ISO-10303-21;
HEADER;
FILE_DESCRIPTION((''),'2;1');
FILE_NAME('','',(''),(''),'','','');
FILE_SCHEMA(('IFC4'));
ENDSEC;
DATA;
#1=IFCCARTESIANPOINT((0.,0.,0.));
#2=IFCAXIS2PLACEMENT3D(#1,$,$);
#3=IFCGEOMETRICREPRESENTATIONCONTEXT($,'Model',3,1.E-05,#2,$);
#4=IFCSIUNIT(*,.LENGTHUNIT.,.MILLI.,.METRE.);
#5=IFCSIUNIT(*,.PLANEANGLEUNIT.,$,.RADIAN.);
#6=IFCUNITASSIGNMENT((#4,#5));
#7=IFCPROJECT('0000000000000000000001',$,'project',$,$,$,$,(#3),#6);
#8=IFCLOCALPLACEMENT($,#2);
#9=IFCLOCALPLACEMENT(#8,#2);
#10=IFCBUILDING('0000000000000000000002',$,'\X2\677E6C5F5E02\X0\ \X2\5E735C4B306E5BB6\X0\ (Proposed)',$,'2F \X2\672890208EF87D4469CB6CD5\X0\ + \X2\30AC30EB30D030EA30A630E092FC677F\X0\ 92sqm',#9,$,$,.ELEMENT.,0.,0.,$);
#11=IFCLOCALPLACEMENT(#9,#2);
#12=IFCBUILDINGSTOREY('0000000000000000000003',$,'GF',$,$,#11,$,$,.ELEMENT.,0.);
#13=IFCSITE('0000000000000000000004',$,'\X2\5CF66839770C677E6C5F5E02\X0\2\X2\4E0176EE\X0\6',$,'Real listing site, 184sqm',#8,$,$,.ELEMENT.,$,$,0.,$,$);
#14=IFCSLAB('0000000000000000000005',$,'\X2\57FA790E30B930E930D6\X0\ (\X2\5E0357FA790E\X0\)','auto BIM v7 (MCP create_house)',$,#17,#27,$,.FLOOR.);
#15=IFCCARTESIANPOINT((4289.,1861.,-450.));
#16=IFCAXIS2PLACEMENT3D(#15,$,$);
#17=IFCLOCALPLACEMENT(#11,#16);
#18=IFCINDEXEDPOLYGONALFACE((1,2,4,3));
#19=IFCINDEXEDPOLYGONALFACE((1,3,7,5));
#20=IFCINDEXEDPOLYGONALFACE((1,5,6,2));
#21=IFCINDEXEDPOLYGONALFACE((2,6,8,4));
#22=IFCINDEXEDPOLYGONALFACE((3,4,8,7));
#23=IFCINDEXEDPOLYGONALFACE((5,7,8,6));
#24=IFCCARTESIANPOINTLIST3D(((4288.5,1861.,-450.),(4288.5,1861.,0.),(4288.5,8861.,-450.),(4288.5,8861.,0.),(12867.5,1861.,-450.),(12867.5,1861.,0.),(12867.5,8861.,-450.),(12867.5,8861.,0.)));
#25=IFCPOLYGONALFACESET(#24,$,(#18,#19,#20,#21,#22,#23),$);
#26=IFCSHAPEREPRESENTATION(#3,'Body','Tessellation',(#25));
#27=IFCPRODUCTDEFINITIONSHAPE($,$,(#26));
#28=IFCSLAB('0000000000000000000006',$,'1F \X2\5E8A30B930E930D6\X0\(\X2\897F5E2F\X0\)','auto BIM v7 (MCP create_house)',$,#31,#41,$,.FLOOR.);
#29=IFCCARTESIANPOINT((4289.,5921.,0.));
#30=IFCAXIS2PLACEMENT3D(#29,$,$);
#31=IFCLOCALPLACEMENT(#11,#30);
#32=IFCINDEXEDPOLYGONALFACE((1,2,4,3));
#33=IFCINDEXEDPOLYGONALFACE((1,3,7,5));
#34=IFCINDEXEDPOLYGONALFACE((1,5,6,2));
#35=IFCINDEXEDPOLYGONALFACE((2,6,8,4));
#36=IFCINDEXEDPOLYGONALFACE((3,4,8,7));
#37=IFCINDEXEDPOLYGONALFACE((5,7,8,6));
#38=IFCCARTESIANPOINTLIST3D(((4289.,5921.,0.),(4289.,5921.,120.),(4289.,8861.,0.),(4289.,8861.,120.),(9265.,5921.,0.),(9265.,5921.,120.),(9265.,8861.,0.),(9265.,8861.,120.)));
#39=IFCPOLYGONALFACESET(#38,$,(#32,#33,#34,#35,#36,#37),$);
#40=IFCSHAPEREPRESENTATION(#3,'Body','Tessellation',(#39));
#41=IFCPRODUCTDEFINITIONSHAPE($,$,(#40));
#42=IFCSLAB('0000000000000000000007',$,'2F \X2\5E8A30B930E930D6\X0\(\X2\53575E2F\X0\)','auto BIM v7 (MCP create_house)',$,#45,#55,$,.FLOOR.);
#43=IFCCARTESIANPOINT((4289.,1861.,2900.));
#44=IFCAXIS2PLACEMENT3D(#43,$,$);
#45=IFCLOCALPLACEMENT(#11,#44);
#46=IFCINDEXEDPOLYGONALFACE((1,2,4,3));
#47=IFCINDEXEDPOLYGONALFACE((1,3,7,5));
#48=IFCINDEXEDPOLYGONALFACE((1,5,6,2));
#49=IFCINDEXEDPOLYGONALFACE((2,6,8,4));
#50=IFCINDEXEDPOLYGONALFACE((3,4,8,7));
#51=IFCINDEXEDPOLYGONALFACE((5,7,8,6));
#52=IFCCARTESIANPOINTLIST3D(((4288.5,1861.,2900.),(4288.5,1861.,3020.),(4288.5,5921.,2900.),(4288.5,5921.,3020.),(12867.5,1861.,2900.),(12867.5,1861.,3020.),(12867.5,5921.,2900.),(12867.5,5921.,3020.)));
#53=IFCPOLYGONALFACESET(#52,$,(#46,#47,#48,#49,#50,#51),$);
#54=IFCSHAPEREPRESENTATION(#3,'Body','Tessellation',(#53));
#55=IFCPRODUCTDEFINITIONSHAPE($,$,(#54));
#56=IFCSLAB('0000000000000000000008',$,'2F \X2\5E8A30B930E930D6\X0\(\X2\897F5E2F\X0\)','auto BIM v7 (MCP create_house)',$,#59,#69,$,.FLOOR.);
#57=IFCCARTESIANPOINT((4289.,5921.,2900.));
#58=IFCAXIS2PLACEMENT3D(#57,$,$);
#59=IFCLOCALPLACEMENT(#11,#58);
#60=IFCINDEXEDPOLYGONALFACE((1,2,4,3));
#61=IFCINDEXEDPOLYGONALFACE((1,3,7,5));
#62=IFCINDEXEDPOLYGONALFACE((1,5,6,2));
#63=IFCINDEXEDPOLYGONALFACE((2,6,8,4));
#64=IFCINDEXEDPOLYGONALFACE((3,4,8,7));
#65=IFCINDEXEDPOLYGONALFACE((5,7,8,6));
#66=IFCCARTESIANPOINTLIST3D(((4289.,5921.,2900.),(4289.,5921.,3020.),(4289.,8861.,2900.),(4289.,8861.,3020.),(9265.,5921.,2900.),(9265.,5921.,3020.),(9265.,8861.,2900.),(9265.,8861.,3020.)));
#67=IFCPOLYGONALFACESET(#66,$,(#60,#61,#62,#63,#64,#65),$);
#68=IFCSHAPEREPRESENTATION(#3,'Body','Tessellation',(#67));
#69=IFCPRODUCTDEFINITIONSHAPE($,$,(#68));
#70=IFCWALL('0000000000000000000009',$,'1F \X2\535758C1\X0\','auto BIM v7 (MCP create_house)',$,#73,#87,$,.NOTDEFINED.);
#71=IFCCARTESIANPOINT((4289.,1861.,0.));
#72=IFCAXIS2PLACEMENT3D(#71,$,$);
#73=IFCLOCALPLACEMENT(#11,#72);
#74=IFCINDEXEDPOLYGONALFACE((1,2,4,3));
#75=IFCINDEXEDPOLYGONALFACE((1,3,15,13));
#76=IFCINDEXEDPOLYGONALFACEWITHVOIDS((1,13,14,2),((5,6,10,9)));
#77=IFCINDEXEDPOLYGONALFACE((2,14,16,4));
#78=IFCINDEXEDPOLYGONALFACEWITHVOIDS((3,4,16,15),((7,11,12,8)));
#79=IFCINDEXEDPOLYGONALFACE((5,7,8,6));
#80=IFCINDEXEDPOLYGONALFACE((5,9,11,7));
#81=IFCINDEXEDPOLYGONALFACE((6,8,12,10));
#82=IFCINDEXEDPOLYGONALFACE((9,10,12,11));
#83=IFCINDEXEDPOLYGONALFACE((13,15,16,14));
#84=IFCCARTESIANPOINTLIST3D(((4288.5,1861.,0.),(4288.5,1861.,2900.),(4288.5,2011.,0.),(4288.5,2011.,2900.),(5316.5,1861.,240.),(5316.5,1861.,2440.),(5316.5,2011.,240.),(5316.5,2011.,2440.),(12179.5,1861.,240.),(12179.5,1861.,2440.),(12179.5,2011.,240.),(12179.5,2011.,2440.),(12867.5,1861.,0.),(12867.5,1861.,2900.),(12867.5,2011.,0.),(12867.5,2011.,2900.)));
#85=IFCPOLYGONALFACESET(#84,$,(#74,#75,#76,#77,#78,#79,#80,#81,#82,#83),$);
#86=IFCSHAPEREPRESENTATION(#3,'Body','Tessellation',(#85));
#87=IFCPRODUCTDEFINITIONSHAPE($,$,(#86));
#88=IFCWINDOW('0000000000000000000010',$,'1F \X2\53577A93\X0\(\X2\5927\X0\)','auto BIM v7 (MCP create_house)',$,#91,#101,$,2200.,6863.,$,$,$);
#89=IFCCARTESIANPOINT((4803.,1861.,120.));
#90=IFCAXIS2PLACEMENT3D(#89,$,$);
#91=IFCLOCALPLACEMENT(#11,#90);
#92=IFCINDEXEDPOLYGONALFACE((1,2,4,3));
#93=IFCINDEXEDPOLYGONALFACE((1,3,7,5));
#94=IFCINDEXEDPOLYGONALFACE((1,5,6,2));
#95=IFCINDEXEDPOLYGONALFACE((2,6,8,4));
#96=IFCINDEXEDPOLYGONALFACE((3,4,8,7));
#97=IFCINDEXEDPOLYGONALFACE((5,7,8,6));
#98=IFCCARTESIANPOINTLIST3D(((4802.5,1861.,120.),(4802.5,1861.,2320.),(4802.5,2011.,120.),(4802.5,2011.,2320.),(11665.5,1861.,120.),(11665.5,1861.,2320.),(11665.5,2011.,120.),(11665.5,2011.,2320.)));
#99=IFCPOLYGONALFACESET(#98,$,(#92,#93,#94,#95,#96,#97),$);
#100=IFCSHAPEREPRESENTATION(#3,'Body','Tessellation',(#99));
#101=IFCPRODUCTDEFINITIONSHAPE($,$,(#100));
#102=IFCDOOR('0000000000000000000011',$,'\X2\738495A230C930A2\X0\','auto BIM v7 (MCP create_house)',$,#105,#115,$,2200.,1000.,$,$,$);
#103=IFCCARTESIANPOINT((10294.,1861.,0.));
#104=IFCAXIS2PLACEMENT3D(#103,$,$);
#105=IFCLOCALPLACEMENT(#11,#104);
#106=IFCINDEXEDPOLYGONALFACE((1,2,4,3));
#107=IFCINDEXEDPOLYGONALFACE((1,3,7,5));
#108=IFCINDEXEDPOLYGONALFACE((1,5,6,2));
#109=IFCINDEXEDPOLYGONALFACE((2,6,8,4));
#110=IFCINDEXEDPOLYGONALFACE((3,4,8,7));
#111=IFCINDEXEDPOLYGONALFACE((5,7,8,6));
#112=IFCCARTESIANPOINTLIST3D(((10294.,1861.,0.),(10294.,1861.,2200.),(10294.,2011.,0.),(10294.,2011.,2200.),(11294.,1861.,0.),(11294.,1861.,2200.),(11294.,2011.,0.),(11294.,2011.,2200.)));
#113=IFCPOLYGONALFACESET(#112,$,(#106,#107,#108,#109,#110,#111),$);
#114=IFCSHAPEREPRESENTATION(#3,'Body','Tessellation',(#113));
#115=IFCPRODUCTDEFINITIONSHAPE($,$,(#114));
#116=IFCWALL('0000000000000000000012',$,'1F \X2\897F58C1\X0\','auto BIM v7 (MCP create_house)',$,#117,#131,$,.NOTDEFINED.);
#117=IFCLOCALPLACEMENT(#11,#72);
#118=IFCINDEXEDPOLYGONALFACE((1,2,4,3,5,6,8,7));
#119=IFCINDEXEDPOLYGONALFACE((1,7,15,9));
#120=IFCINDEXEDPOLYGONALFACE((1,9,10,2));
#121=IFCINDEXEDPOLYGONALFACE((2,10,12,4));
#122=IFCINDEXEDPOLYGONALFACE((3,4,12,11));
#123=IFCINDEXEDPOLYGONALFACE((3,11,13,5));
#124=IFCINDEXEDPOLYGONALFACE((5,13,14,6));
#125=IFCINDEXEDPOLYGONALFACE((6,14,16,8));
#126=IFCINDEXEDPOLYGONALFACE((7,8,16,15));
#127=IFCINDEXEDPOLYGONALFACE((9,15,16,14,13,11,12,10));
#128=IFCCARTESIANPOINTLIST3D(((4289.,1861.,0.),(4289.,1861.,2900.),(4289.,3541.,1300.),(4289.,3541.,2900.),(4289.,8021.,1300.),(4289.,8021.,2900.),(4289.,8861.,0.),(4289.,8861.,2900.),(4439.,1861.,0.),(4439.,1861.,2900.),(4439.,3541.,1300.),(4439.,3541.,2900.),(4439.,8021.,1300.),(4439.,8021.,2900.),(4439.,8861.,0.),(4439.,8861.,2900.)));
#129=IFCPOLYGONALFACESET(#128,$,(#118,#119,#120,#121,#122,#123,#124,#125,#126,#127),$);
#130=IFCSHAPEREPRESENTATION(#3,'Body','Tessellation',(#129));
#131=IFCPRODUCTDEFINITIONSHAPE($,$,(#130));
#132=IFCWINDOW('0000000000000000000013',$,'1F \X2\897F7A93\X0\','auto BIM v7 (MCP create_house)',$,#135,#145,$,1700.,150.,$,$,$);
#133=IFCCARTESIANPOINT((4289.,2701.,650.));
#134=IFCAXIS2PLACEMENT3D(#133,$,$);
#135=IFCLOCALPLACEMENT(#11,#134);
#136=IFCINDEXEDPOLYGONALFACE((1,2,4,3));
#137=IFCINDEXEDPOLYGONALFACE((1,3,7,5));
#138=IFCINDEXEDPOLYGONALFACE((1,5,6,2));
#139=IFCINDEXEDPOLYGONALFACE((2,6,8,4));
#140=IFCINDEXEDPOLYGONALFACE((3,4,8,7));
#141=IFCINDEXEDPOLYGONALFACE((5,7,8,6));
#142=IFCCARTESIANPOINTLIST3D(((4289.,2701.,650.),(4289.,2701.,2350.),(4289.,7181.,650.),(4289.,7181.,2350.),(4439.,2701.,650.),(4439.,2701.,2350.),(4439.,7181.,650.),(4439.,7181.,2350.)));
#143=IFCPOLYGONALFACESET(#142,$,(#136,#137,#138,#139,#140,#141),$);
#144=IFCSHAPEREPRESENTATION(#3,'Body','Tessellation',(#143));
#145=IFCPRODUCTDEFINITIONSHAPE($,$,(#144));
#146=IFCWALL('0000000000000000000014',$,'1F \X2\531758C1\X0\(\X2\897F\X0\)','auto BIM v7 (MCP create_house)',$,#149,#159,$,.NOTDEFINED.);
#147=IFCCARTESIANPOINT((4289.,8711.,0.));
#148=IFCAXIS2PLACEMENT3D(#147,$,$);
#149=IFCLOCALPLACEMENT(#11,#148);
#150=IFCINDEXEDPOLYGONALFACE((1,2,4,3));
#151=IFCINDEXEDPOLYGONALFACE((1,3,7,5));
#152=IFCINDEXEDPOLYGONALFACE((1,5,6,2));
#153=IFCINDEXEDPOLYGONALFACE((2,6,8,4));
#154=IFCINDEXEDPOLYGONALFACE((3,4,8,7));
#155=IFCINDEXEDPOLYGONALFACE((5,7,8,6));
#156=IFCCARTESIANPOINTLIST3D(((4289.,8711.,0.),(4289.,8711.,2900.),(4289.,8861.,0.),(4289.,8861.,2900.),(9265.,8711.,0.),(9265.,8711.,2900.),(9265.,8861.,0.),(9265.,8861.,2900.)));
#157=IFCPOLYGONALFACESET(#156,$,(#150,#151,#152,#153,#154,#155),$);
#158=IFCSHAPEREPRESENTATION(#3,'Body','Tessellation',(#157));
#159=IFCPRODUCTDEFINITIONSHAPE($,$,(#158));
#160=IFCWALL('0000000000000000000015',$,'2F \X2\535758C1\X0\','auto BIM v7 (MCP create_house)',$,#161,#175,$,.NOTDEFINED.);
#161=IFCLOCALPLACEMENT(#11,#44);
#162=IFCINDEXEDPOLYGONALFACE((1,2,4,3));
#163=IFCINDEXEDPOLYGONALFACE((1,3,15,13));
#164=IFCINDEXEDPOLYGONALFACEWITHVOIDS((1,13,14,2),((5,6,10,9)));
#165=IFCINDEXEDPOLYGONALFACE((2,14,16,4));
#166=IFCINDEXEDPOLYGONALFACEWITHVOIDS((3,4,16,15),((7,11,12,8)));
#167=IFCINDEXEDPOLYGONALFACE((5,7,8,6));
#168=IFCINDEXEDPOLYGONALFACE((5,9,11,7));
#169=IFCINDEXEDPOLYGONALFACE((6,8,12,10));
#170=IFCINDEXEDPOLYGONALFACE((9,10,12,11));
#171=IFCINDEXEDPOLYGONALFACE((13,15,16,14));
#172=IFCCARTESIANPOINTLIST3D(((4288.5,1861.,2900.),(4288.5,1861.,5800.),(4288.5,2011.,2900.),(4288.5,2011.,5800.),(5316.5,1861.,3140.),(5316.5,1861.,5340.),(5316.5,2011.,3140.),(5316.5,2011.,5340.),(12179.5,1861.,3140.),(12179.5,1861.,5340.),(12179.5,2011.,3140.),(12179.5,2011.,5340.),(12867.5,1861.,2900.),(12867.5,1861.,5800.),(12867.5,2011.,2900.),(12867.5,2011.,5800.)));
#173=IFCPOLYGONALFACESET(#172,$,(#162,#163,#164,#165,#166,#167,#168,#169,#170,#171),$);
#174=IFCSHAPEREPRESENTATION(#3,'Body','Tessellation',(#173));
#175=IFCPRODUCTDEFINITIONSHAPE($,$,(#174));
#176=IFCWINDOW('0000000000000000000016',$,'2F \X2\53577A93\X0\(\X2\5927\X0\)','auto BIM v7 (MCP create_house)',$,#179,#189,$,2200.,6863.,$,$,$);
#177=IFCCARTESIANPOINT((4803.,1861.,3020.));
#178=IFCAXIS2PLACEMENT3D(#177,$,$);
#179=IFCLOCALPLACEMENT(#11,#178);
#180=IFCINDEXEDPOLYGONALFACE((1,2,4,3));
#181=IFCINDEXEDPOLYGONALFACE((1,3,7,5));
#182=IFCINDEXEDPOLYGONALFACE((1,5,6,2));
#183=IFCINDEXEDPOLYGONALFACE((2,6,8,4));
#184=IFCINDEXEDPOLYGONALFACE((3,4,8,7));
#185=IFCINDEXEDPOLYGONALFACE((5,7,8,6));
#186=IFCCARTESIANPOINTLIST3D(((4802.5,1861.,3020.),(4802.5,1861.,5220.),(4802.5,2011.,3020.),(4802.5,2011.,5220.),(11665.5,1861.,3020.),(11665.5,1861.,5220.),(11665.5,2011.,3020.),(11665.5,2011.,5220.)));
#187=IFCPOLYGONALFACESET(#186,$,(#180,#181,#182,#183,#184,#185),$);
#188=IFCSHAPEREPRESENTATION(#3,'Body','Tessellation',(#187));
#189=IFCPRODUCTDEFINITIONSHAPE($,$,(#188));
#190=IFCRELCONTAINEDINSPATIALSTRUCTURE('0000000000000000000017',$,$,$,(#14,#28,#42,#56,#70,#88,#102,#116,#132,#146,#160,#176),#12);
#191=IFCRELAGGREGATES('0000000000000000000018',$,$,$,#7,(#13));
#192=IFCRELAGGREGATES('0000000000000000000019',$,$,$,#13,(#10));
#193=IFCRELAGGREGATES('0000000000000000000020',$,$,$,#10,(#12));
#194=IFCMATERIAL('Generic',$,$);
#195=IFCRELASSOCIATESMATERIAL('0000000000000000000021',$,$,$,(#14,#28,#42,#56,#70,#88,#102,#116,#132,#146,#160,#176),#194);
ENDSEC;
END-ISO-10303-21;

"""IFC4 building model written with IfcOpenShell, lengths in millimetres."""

from ifc_helpers import new_model, si_unit, frame, frame_2d, origin, place, context, project, spatial, rectangle, extrude, material, element, fill, save


model = new_model("IFC4")

# Units and contexts
model_context = context("Model", 3, precision=1e-05, world=origin())
ifc_project = project(units=[si_unit("LENGTHUNIT", "METRE", prefix="MILLI"), si_unit("PLANEANGLEUNIT", "RADIAN")], contexts=[model_context])

# Site, building, storey
site_placement = place(None, origin())
site = spatial("IfcSite", under=ifc_project, at=site_placement, Name="島根県松江市2丁目6", ObjectType="Real listing site, 184sqm", CompositionType="ELEMENT", RefElevation=0.0)
building_placement = place(site_placement, origin())
building = spatial("IfcBuilding", under=site, at=building_placement, Name="松江市 平屋の家 (Proposed)", ObjectType="2F 木造軸組構法 + ガルバリウム鋼板 92sqm", CompositionType="ELEMENT", ElevationOfRefHeight=0.0, ElevationOfTerrain=0.0)
storey_placement = place(building_placement, origin())
storey = spatial("IfcBuildingStorey", under=building, at=storey_placement, Name="GF", CompositionType="ELEMENT", Elevation=0.0)

# Slabs
ifc_material = material(Name="Generic")
slab_1_placement = place(storey_placement, frame((4289.0, 1861.0, -450.0)))
element("IfcSlab", 1, at=slab_1_placement, inside=storey, material=ifc_material, Name="基礎スラブ (布基礎)", Description="auto BIM v7 (MCP create_house)", PredefinedType="FLOOR", context=model_context, shape_type="SweptSolid", body=[
    extrude(rectangle(XDim=8579.0, YDim=7000.0, at=frame_2d((4289.0, 3500.0))), frame((4289.0, 1861.0, -450.0)), (0.0, 0.0, 1.0), 450.0),
])
slab_2_placement = place(storey_placement, frame((4289.0, 5921.0, 0.0)))
element("IfcSlab", 2, at=slab_2_placement, inside=storey, material=ifc_material, Name="1F 床スラブ(西帯)", Description="auto BIM v7 (MCP create_house)", PredefinedType="FLOOR", context=model_context, shape_type="SweptSolid", body=[
    extrude(rectangle(XDim=4976.0, YDim=2940.0, at=frame_2d((2488.0, 1470.0))), frame((4289.0, 5921.0, 0.0)), (0.0, 0.0, 1.0), 120.0),
])
slab_3_placement = place(storey_placement, frame((4289.0, 1861.0, 2900.0)))
element("IfcSlab", 3, at=slab_3_placement, inside=storey, material=ifc_material, Name="2F 床スラブ(南帯)", Description="auto BIM v7 (MCP create_house)", PredefinedType="FLOOR", context=model_context, shape_type="SweptSolid", body=[
    extrude(rectangle(XDim=8579.0, YDim=4060.0, at=frame_2d((4289.0, 2030.0))), frame((4289.0, 1861.0, 2900.0)), (0.0, 0.0, 1.0), 120.0),
])
slab_4_placement = place(storey_placement, frame((4289.0, 5921.0, 2900.0)))
element("IfcSlab", 4, at=slab_4_placement, inside=storey, material=ifc_material, Name="2F 床スラブ(西帯)", Description="auto BIM v7 (MCP create_house)", PredefinedType="FLOOR", context=model_context, shape_type="SweptSolid", body=[
    extrude(rectangle(XDim=4976.0, YDim=2940.0, at=frame_2d((2488.0, 1470.0))), frame((4289.0, 5921.0, 2900.0)), (0.0, 0.0, 1.0), 120.0),
])

# Wall, openings, window, door
wall_1_placement = place(storey_placement, frame((4289.0, 1861.0, 0.0)))
wall_1 = element("IfcWall", 5, at=wall_1_placement, inside=storey, material=ifc_material, Name="1F 南壁", Description="auto BIM v7 (MCP create_house)", PredefinedType="NOTDEFINED", context=model_context, shape_type="SweptSolid", body=[
    extrude(rectangle(XDim=8579.0, YDim=150.0, at=frame_2d((4289.0, 75.0))), frame((4289.0, 1861.0, 0.0)), (0.0, 0.0, 1.0), 2900.0),
])
opening_1_placement = place(storey_placement, frame((4803.0, 1861.0, 120.0)))
opening_1 = element("IfcOpeningElement", 6, at=opening_1_placement, cuts=wall_1, PredefinedType="NOTDEFINED", context=model_context, shape_type="SweptSolid", body=[
    extrude(rectangle(XDim=6863.0, YDim=150.0, at=frame_2d((3431.0, 75.0))), frame((4803.0, 1861.0, 120.0)), (0.0, 0.0, 1.0), 2200.0),
])
opening_2_placement = place(storey_placement, frame((10294.0, 1861.0, 0.0)))
opening_2 = element("IfcOpeningElement", 7, at=opening_2_placement, cuts=wall_1, PredefinedType="NOTDEFINED", context=model_context, shape_type="SweptSolid", body=[
    extrude(rectangle(XDim=1000.0, YDim=150.0, at=frame_2d((500.0, 75.0))), frame((10294.0, 1861.0, 0.0)), (0.0, 0.0, 1.0), 2200.0),
])
window_1_placement = place(storey_placement, frame((4803.0, 1861.0, 120.0)))
window_1 = element("IfcWindow", 8, at=window_1_placement, inside=storey, material=ifc_material, Name="1F 南窓(大)", Description="auto BIM v7 (MCP create_house)", OverallHeight=2200.0, OverallWidth=6863.0, context=model_context, shape_type="SweptSolid", body=[
    extrude(rectangle(XDim=6863.0, YDim=150.0, at=frame_2d((3431.0, 75.0))), frame((4803.0, 1861.0, 120.0)), (0.0, 0.0, 1.0), 2200.0),
])
fill(opening_1, window_1)
door_placement = place(storey_placement, frame((10294.0, 1861.0, 0.0)))
door = element("IfcDoor", 9, at=door_placement, inside=storey, material=ifc_material, Name="玄関ドア", Description="auto BIM v7 (MCP create_house)", OverallHeight=2200.0, OverallWidth=1000.0, context=model_context, shape_type="SweptSolid", body=[
    extrude(rectangle(XDim=1000.0, YDim=150.0, at=frame_2d((500.0, 75.0))), frame((10294.0, 1861.0, 0.0)), (0.0, 0.0, 1.0), 2200.0),
])
fill(opening_2, door)

# Wall, opening, window
wall_2_placement = place(storey_placement, frame((4289.0, 1861.0, 0.0)))
wall_2 = element("IfcWall", 10, at=wall_2_placement, inside=storey, material=ifc_material, Name="1F 西壁", Description="auto BIM v7 (MCP create_house)", PredefinedType="NOTDEFINED", context=model_context, shape_type="SweptSolid", body=[
    extrude(rectangle(XDim=150.0, YDim=7000.0, at=frame_2d((75.0, 3500.0))), frame((4289.0, 1861.0, 0.0)), (0.0, 0.0, 1.0), 2900.0),
])
opening_3_placement = place(storey_placement, frame((4289.0, 2701.0, 650.0)))
opening_3 = element("IfcOpeningElement", 11, at=opening_3_placement, cuts=wall_2, PredefinedType="NOTDEFINED", context=model_context, shape_type="SweptSolid", body=[
    extrude(rectangle(XDim=150.0, YDim=4480.0, at=frame_2d((75.0, 2240.0))), frame((4289.0, 2701.0, 650.0)), (0.0, 0.0, 1.0), 1700.0),
])
window_2_placement = place(storey_placement, frame((4289.0, 2701.0, 650.0)))
window_2 = element("IfcWindow", 12, at=window_2_placement, inside=storey, material=ifc_material, Name="1F 西窓", Description="auto BIM v7 (MCP create_house)", OverallHeight=1700.0, OverallWidth=150.0, context=model_context, shape_type="SweptSolid", body=[
    extrude(rectangle(XDim=150.0, YDim=4480.0, at=frame_2d((75.0, 2240.0))), frame((4289.0, 2701.0, 650.0)), (0.0, 0.0, 1.0), 1700.0),
])
fill(opening_3, window_2)

# Wall
wall_3_placement = place(storey_placement, frame((4289.0, 8711.0, 0.0)))
element("IfcWall", 13, at=wall_3_placement, inside=storey, material=ifc_material, Name="1F 北壁(西)", Description="auto BIM v7 (MCP create_house)", PredefinedType="NOTDEFINED", context=model_context, shape_type="SweptSolid", body=[
    extrude(rectangle(XDim=4976.0, YDim=150.0, at=frame_2d((2488.0, 75.0))), frame((4289.0, 8711.0, 0.0)), (0.0, 0.0, 1.0), 2900.0),
])

# Wall, opening, window
wall_4_placement = place(storey_placement, frame((4289.0, 1861.0, 2900.0)))
wall_4 = element("IfcWall", 14, at=wall_4_placement, inside=storey, material=ifc_material, Name="2F 南壁", Description="auto BIM v7 (MCP create_house)", PredefinedType="NOTDEFINED", context=model_context, shape_type="SweptSolid", body=[
    extrude(rectangle(XDim=8579.0, YDim=150.0, at=frame_2d((4289.0, 75.0))), frame((4289.0, 1861.0, 2900.0)), (0.0, 0.0, 1.0), 2900.0),
])
opening_4_placement = place(storey_placement, frame((4803.0, 1861.0, 3020.0)))
opening_4 = element("IfcOpeningElement", 15, at=opening_4_placement, cuts=wall_4, PredefinedType="NOTDEFINED", context=model_context, shape_type="SweptSolid", body=[
    extrude(rectangle(XDim=6863.0, YDim=150.0, at=frame_2d((3431.0, 75.0))), frame((4803.0, 1861.0, 3020.0)), (0.0, 0.0, 1.0), 2200.0),
])
window_3_placement = place(storey_placement, frame((4803.0, 1861.0, 3020.0)))
window_3 = element("IfcWindow", 16, at=window_3_placement, inside=storey, material=ifc_material, Name="2F 南窓(大)", Description="auto BIM v7 (MCP create_house)", OverallHeight=2200.0, OverallWidth=6863.0, context=model_context, shape_type="SweptSolid", body=[
    extrude(rectangle(XDim=6863.0, YDim=150.0, at=frame_2d((3431.0, 75.0))), frame((4803.0, 1861.0, 3020.0)), (0.0, 0.0, 1.0), 2200.0),
])
fill(opening_4, window_3)

save(model, "model.ifc")
